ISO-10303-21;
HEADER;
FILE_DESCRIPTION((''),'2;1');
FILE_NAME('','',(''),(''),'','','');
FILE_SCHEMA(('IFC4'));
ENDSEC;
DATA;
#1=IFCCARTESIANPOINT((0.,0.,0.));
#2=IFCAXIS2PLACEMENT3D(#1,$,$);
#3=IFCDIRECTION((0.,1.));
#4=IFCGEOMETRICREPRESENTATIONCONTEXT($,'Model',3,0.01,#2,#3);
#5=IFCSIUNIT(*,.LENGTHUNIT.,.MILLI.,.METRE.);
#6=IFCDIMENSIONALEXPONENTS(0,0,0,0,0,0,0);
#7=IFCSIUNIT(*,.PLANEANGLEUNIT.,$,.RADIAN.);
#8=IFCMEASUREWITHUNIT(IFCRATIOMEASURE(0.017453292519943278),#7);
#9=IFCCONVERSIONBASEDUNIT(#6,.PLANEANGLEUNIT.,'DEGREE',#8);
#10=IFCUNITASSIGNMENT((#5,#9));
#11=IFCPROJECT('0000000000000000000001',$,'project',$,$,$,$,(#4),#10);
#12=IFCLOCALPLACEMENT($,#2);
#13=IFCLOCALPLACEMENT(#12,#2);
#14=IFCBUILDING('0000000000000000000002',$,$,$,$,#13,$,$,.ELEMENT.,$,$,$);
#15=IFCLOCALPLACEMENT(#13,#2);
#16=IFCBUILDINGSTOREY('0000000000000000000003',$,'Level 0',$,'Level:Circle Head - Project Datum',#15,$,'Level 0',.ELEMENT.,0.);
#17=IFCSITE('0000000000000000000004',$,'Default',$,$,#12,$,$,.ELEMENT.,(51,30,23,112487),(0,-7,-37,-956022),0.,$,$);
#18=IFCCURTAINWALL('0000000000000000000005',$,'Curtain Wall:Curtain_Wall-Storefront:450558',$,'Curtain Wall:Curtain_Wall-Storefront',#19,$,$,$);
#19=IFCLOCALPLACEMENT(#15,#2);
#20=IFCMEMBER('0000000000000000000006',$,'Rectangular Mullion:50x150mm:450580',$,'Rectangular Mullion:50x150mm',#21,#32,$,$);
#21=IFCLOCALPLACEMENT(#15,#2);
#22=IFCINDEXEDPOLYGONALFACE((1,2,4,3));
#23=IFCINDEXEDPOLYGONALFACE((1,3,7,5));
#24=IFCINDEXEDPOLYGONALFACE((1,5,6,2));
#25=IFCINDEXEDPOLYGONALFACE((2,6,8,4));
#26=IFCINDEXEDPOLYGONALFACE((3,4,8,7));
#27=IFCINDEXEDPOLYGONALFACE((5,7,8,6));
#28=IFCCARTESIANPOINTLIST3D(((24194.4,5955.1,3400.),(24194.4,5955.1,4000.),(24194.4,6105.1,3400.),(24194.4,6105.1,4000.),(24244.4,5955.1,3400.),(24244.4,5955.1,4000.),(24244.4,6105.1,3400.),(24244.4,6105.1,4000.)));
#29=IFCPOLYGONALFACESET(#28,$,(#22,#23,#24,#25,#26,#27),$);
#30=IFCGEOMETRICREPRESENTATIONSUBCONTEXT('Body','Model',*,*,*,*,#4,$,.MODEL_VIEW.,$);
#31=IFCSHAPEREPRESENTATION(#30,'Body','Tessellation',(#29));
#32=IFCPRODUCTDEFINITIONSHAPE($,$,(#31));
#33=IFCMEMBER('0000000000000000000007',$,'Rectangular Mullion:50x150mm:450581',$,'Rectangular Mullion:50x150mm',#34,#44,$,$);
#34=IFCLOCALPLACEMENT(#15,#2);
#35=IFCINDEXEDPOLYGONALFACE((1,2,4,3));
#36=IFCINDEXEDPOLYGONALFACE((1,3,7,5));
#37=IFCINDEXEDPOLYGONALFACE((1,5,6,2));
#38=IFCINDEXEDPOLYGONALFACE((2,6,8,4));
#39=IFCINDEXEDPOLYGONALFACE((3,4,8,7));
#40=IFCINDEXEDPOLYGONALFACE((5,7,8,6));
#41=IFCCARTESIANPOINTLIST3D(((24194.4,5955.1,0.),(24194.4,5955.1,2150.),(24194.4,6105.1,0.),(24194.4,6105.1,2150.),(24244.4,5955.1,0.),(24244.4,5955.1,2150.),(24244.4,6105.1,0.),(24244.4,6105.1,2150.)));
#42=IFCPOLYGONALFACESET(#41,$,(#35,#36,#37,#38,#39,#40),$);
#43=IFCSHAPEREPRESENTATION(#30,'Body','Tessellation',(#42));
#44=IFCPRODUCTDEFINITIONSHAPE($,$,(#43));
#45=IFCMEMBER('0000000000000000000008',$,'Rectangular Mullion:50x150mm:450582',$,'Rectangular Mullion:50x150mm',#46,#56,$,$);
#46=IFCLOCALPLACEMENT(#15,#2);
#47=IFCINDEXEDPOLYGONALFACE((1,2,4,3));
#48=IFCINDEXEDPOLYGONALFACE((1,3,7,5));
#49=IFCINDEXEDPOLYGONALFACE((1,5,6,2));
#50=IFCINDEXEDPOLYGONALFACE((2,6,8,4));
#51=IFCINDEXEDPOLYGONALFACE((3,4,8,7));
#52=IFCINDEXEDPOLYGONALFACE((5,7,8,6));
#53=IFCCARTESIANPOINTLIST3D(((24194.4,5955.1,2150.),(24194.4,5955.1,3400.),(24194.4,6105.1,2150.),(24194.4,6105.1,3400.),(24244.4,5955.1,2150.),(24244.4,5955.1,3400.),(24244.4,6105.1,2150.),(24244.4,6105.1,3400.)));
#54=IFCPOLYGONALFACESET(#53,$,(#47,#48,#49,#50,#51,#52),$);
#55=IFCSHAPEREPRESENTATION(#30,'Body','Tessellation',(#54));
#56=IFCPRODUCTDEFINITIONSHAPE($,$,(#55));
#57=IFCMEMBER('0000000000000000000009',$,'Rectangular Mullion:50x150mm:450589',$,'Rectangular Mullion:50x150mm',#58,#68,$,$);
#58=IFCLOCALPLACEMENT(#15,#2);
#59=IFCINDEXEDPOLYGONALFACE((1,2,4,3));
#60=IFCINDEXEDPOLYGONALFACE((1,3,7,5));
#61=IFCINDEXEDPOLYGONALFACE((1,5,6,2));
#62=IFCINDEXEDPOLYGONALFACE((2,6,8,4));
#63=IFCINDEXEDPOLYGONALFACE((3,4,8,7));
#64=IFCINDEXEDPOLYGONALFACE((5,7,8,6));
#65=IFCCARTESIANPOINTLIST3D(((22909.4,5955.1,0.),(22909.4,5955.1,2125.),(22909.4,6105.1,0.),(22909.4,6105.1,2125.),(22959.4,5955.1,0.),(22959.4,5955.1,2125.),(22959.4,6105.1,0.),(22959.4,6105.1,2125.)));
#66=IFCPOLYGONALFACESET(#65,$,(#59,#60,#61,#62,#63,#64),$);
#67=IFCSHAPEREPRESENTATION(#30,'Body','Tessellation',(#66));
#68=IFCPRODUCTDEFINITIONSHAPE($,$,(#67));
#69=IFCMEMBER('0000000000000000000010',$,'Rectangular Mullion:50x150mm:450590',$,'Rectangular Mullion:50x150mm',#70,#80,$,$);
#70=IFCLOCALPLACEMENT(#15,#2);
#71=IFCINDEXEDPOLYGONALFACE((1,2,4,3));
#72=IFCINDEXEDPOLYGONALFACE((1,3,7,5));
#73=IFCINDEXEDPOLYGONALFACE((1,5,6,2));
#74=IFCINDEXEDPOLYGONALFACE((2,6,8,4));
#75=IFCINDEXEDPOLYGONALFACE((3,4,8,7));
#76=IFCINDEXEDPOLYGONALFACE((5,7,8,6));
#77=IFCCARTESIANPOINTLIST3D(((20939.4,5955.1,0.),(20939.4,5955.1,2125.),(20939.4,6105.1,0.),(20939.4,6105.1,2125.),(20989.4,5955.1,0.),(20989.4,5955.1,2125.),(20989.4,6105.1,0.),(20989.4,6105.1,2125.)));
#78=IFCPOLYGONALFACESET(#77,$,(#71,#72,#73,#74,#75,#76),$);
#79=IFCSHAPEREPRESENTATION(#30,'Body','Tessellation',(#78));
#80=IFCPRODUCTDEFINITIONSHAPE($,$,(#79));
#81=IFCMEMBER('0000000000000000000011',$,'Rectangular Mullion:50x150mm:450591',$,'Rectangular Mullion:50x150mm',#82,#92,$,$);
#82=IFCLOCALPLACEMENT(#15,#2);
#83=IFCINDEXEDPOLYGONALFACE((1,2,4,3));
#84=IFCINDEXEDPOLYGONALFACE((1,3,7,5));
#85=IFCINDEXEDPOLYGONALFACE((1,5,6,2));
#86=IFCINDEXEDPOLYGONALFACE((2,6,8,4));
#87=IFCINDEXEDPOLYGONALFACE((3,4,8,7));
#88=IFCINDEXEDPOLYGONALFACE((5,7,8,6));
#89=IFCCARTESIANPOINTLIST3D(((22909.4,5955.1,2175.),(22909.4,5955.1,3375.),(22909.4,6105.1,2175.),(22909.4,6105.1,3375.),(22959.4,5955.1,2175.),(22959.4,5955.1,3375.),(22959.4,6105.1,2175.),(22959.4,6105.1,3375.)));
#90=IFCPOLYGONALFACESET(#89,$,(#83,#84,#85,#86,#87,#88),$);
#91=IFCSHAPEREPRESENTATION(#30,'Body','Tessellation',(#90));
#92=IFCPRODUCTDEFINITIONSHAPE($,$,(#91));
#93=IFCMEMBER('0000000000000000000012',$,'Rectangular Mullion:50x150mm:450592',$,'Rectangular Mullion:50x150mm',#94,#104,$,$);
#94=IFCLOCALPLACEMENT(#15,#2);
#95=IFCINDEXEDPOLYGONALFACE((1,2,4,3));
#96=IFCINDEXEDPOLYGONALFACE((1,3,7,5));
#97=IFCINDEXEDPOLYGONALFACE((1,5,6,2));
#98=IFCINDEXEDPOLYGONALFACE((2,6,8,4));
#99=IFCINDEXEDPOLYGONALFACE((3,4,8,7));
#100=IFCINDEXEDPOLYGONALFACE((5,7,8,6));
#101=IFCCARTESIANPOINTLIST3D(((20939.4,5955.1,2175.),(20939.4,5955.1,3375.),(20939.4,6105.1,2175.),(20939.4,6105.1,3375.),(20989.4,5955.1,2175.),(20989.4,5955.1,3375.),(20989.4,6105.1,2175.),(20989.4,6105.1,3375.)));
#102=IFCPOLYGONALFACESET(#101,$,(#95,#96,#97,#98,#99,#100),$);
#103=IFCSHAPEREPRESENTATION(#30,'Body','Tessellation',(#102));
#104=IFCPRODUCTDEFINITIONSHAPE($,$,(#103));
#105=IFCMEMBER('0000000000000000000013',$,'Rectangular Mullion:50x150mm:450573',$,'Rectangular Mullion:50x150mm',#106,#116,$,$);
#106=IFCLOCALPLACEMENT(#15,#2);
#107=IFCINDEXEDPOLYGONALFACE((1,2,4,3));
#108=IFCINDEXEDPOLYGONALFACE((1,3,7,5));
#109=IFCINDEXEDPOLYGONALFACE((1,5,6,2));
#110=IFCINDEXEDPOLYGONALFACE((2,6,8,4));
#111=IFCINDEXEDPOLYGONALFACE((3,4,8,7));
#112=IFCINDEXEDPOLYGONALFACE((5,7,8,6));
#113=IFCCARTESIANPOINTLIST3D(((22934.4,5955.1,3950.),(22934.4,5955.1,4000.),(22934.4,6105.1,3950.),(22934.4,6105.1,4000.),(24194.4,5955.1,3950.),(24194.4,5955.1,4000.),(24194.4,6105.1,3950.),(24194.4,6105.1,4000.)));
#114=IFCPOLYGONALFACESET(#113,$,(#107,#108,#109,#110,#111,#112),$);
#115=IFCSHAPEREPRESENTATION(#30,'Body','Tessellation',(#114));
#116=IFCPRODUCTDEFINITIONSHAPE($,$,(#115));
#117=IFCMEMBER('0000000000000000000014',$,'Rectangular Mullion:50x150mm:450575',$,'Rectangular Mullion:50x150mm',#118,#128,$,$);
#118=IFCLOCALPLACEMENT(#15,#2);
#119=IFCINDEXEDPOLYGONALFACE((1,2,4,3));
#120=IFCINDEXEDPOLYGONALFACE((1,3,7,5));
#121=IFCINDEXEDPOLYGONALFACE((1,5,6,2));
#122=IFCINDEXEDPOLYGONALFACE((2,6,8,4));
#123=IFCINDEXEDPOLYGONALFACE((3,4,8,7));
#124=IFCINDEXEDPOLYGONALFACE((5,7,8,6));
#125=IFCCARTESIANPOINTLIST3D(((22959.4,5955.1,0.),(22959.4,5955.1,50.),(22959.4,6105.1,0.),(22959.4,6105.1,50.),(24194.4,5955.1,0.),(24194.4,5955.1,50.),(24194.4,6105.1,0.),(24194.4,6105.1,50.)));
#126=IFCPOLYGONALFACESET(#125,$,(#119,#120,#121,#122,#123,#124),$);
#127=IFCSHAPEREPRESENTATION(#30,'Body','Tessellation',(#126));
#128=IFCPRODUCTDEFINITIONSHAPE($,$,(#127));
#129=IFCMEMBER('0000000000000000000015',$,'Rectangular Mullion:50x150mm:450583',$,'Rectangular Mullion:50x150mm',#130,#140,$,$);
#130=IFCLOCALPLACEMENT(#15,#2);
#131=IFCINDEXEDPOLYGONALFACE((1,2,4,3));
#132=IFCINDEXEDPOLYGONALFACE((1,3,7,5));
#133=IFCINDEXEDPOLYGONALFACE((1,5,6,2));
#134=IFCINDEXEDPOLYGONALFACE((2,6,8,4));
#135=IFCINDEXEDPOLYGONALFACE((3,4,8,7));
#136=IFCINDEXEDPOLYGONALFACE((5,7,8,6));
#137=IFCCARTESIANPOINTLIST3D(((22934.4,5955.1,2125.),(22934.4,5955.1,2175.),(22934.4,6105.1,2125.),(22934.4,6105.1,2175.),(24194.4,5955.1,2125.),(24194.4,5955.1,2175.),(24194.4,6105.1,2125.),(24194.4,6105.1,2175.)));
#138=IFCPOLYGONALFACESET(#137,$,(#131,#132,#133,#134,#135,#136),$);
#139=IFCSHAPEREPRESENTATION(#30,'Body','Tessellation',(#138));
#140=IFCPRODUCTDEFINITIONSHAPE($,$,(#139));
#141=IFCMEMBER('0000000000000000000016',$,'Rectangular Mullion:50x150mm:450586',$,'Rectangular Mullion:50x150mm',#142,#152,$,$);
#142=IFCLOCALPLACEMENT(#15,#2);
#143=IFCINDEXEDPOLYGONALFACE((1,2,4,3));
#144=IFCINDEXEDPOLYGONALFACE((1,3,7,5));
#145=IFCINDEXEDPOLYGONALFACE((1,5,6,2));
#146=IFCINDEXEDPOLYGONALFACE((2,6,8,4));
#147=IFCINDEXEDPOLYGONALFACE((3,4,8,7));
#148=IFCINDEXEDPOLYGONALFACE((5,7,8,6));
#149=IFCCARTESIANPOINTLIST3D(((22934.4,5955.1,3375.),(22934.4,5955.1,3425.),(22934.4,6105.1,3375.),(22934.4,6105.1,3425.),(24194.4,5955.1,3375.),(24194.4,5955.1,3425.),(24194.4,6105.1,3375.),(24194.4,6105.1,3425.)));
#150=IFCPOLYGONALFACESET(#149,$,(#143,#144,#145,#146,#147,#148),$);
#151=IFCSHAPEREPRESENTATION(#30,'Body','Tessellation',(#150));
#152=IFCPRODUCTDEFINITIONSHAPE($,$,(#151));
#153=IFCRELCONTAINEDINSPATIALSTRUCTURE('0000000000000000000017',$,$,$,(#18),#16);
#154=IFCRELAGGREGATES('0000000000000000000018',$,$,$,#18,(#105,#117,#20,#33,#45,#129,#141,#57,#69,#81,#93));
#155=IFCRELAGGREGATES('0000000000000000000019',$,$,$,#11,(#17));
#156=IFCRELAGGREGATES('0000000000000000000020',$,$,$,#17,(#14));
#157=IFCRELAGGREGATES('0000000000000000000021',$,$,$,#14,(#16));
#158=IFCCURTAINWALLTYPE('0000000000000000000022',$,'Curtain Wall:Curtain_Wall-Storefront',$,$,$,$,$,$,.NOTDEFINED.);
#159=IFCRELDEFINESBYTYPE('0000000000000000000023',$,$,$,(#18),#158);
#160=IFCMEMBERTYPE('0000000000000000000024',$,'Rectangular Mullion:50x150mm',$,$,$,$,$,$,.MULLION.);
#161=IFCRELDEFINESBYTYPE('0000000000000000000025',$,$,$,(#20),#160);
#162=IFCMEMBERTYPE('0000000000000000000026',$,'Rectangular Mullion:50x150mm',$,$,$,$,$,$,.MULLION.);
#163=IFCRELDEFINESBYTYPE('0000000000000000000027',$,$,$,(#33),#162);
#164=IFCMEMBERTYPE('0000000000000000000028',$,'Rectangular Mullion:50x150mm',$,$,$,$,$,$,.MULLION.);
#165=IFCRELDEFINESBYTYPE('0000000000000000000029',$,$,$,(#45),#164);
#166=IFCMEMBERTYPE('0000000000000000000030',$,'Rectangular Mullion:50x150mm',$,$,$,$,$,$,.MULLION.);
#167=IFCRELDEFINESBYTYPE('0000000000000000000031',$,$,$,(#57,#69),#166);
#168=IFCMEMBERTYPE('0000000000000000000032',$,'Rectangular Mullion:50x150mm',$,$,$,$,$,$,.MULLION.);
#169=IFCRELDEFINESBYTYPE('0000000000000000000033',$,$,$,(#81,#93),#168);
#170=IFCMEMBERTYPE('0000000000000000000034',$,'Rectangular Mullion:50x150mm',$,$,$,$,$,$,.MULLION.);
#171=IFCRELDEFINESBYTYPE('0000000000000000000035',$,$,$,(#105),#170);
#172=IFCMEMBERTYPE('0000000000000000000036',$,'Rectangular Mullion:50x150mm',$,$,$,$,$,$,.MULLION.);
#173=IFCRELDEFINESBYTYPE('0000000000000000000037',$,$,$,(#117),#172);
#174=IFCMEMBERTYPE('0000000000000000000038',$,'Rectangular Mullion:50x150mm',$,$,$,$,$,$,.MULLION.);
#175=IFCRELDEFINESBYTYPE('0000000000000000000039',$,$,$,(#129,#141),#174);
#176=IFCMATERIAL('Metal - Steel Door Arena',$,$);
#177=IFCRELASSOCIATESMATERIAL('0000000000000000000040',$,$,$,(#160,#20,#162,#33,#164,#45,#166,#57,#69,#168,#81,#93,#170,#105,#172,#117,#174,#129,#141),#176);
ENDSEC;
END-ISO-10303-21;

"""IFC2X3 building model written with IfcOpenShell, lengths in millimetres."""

from ifc_helpers import new_model, entity, si_unit, converted_unit, direction, frame, origin, origin_2d_with_axis, place, context, subcontext, project, spatial, rectangle, extrude, source, transform, mapped, material, type_object, type_shapes, element, aggregate, save


model = new_model("IFC2X3")

# Units and contexts
model_context = context("Model", 3, precision=0.01, world=origin(), true_north=direction((0.0, 1.0)))
body_context = subcontext(model_context, "Body", "Model", "MODEL_VIEW")
ifc_project = project(units=[si_unit("LENGTHUNIT", "METRE", prefix="MILLI"), converted_unit("PLANEANGLEUNIT", "DEGREE", entity("IfcRatioMeasure", 0.017453292519943278), si_unit("PLANEANGLEUNIT", "RADIAN"), dimensions=[0, 0, 0, 0, 0, 0, 0])], contexts=[model_context])

# Site, building, storey
site_placement = place(None, origin())
site = spatial("IfcSite", under=ifc_project, at=site_placement, Name="Default", CompositionType="ELEMENT", RefLatitude=(51, 30, 23, 112487), RefLongitude=(0, -7, -37, -956022), RefElevation=0.0)
building_placement = place(site_placement, origin())
building = spatial("IfcBuilding", under=site, at=building_placement, CompositionType="ELEMENT")
storey_placement = place(building_placement, origin())
storey = spatial("IfcBuildingStorey", under=building, at=storey_placement, Name="Level 0", ObjectType="Level:Circle Head - Project Datum", LongName="Level 0", CompositionType="ELEMENT", Elevation=0.0)

# Curtain wall, members
curtain_wall_type = type_object("IfcCurtainWallType", Name="Curtain Wall:Curtain_Wall-Storefront", PredefinedType="NOTDEFINED")
curtain_wall_placement = place(storey_placement, origin())
curtain_wall = element("IfcCurtainWall", 1, at=curtain_wall_placement, inside=storey, type_object=curtain_wall_type, Name="Curtain Wall:Curtain_Wall-Storefront:450558", ObjectType="Curtain Wall:Curtain_Wall-Storefront")
ifc_material_1 = material(Name="Metal - Steel Door Arena")
member_type_1 = type_object("IfcMemberType", Name="Rectangular Mullion:50x150mm", PredefinedType="MULLION", material=ifc_material_1)
shared_shape_1 = source(origin(), body_context, "Body", "SweptSolid", [
    extrude(rectangle(XDim=150.0, YDim=50.0, at=origin_2d_with_axis()), frame((-25.0, 0.0, -600.0), z_axis=(0.0, 0.0, 1.0), x_axis=(0.0, -1.0, 0.0)), (0.0, 0.0, 1.0), 600.0),
])
type_shapes(member_type_1, [shared_shape_1])
member_1_placement = place(curtain_wall_placement, frame((24244.4, 6030.1, 4000.0)))
member_1 = element("IfcMember", 2, at=member_1_placement, type_object=member_type_1, material=ifc_material_1, Name="Rectangular Mullion:50x150mm:450580", ObjectType="Rectangular Mullion:50x150mm", context=body_context, shape_type="MappedRepresentation", body=[
    mapped(shared_shape_1, transform((0.0, 0.0, 0.0), scale=1.0)),
])
member_type_2 = type_object("IfcMemberType", Name="Rectangular Mullion:50x150mm", PredefinedType="MULLION", material=ifc_material_1)
shared_shape_2 = source(origin(), body_context, "Body", "SweptSolid", [
    extrude(rectangle(XDim=150.0, YDim=50.0, at=origin_2d_with_axis()), frame((-25.0, 0.0, -2150.0), z_axis=(0.0, 0.0, 1.0), x_axis=(0.0, -1.0, 0.0)), (0.0, 0.0, 1.0), 2150.0),
])
type_shapes(member_type_2, [shared_shape_2])
member_2_placement = place(curtain_wall_placement, frame((24244.4, 6030.1, 2150.0)))
member_2 = element("IfcMember", 3, at=member_2_placement, type_object=member_type_2, material=ifc_material_1, Name="Rectangular Mullion:50x150mm:450581", ObjectType="Rectangular Mullion:50x150mm", context=body_context, shape_type="MappedRepresentation", body=[
    mapped(shared_shape_2, transform((0.0, 0.0, 0.0), scale=1.0)),
])
member_type_3 = type_object("IfcMemberType", Name="Rectangular Mullion:50x150mm", PredefinedType="MULLION", material=ifc_material_1)
shared_shape_3 = source(origin(), body_context, "Body", "SweptSolid", [
    extrude(rectangle(XDim=150.0, YDim=50.0, at=origin_2d_with_axis()), frame((-25.0, 0.0, -1250.0), z_axis=(0.0, 0.0, 1.0), x_axis=(0.0, -1.0, 0.0)), (0.0, 0.0, 1.0), 1250.0),
])
type_shapes(member_type_3, [shared_shape_3])
member_3_placement = place(curtain_wall_placement, frame((24244.4, 6030.1, 3400.0)))
member_3 = element("IfcMember", 4, at=member_3_placement, type_object=member_type_3, material=ifc_material_1, Name="Rectangular Mullion:50x150mm:450582", ObjectType="Rectangular Mullion:50x150mm", context=body_context, shape_type="MappedRepresentation", body=[
    mapped(shared_shape_3, transform((0.0, 0.0, 0.0), scale=1.0)),
])
member_type_4 = type_object("IfcMemberType", Name="Rectangular Mullion:50x150mm", PredefinedType="MULLION", material=ifc_material_1)
shared_shape_4 = source(origin(), body_context, "Body", "SweptSolid", [
    extrude(rectangle(XDim=150.0, YDim=50.0, at=origin_2d_with_axis()), frame((0.0, 0.0, -2125.0), z_axis=(0.0, 0.0, 1.0), x_axis=(0.0, -1.0, 0.0)), (0.0, 0.0, 1.0), 2125.0),
])
type_shapes(member_type_4, [shared_shape_4])
member_4_placement = place(curtain_wall_placement, frame((22934.4, 6030.1, 0.0), z_axis=(0.0, 0.0, -1.0), x_axis=(-1.0, 0.0, 0.0)))
member_4 = element("IfcMember", 5, at=member_4_placement, type_object=member_type_4, material=ifc_material_1, Name="Rectangular Mullion:50x150mm:450589", ObjectType="Rectangular Mullion:50x150mm", context=body_context, shape_type="MappedRepresentation", body=[
    mapped(shared_shape_4, transform((0.0, 0.0, 0.0), scale=1.0)),
])
member_5_placement = place(curtain_wall_placement, frame((20964.4, 6030.1, 0.0), z_axis=(0.0, 0.0, -1.0), x_axis=(-1.0, 0.0, 0.0)))
member_5 = element("IfcMember", 6, at=member_5_placement, type_object=member_type_4, material=ifc_material_1, Name="Rectangular Mullion:50x150mm:450590", ObjectType="Rectangular Mullion:50x150mm", context=body_context, shape_type="MappedRepresentation", body=[
    mapped(shared_shape_4, transform((0.0, 0.0, 0.0), scale=1.0)),
])
member_type_5 = type_object("IfcMemberType", Name="Rectangular Mullion:50x150mm", PredefinedType="MULLION", material=ifc_material_1)
shared_shape_5 = source(origin(), body_context, "Body", "SweptSolid", [
    extrude(rectangle(XDim=150.0, YDim=50.0, at=origin_2d_with_axis()), frame((0.0, 0.0, -1200.0), z_axis=(0.0, 0.0, 1.0), x_axis=(0.0, -1.0, 0.0)), (0.0, 0.0, 1.0), 1200.0),
])
type_shapes(member_type_5, [shared_shape_5])
member_6_placement = place(curtain_wall_placement, frame((22934.4, 6030.1, 2175.0), z_axis=(0.0, 0.0, -1.0), x_axis=(-1.0, 0.0, 0.0)))
member_6 = element("IfcMember", 7, at=member_6_placement, type_object=member_type_5, material=ifc_material_1, Name="Rectangular Mullion:50x150mm:450591", ObjectType="Rectangular Mullion:50x150mm", context=body_context, shape_type="MappedRepresentation", body=[
    mapped(shared_shape_5, transform((0.0, 0.0, 0.0), scale=1.0)),
])
member_7_placement = place(curtain_wall_placement, frame((20964.4, 6030.1, 2175.0), z_axis=(0.0, 0.0, -1.0), x_axis=(-1.0, 0.0, 0.0)))
member_7 = element("IfcMember", 8, at=member_7_placement, type_object=member_type_5, material=ifc_material_1, Name="Rectangular Mullion:50x150mm:450592", ObjectType="Rectangular Mullion:50x150mm", context=body_context, shape_type="MappedRepresentation", body=[
    mapped(shared_shape_5, transform((0.0, 0.0, 0.0), scale=1.0)),
])
member_type_6 = type_object("IfcMemberType", Name="Rectangular Mullion:50x150mm", PredefinedType="MULLION", material=ifc_material_1)
shared_shape_6 = source(origin(), body_context, "Body", "SweptSolid", [
    extrude(rectangle(XDim=150.0, YDim=50.0, at=origin_2d_with_axis()), frame((-25.0, 0.0, -1260.0), z_axis=(0.0, 0.0, 1.0), x_axis=(0.0, -1.0, 0.0)), (0.0, 0.0, 1.0), 1260.0),
])
type_shapes(member_type_6, [shared_shape_6])
member_8_placement = place(curtain_wall_placement, frame((22934.4, 6030.1, 4000.0), z_axis=(-1.0, 0.0, 0.0), x_axis=(0.0, 0.0, 1.0)))
member_8 = element("IfcMember", 9, at=member_8_placement, type_object=member_type_6, material=ifc_material_1, Name="Rectangular Mullion:50x150mm:450573", ObjectType="Rectangular Mullion:50x150mm", context=body_context, shape_type="MappedRepresentation", body=[
    mapped(shared_shape_6, transform((0.0, 0.0, 0.0), scale=1.0)),
])
member_type_7 = type_object("IfcMemberType", Name="Rectangular Mullion:50x150mm", PredefinedType="MULLION", material=ifc_material_1)
shared_shape_7 = source(origin(), body_context, "Body", "SweptSolid", [
    extrude(rectangle(XDim=150.0, YDim=50.0, at=origin_2d_with_axis()), frame((-25.0, 0.0, -1235.0), z_axis=(0.0, 0.0, 1.0), x_axis=(0.0, -1.0, 0.0)), (0.0, 0.0, 1.0), 1235.0),
])
type_shapes(member_type_7, [shared_shape_7])
member_9_placement = place(curtain_wall_placement, frame((24194.4, 6030.1, 0.0), z_axis=(1.0, 0.0, 0.0), x_axis=(0.0, 0.0, -1.0)))
member_9 = element("IfcMember", 10, at=member_9_placement, type_object=member_type_7, material=ifc_material_1, Name="Rectangular Mullion:50x150mm:450575", ObjectType="Rectangular Mullion:50x150mm", context=body_context, shape_type="MappedRepresentation", body=[
    mapped(shared_shape_7, transform((0.0, 0.0, 0.0), scale=1.0)),
])
member_type_8 = type_object("IfcMemberType", Name="Rectangular Mullion:50x150mm", PredefinedType="MULLION", material=ifc_material_1)
shared_shape_8 = source(origin(), body_context, "Body", "SweptSolid", [
    extrude(rectangle(XDim=150.0, YDim=50.0, at=origin_2d_with_axis()), frame((0.0, 0.0, -1260.0), z_axis=(0.0, 0.0, 1.0), x_axis=(0.0, -1.0, 0.0)), (0.0, 0.0, 1.0), 1260.0),
])
type_shapes(member_type_8, [shared_shape_8])
member_10_placement = place(curtain_wall_placement, frame((22934.4, 6030.1, 2150.0), z_axis=(-1.0, 0.0, 0.0), x_axis=(0.0, 0.0, 1.0)))
member_10 = element("IfcMember", 11, at=member_10_placement, type_object=member_type_8, material=ifc_material_1, Name="Rectangular Mullion:50x150mm:450583", ObjectType="Rectangular Mullion:50x150mm", context=body_context, shape_type="MappedRepresentation", body=[
    mapped(shared_shape_8, transform((0.0, 0.0, 0.0), scale=1.0)),
])
member_11_placement = place(curtain_wall_placement, frame((22934.4, 6030.1, 3400.0), z_axis=(-1.0, 0.0, 0.0), x_axis=(0.0, 0.0, 1.0)))
member_11 = element("IfcMember", 12, at=member_11_placement, type_object=member_type_8, material=ifc_material_1, Name="Rectangular Mullion:50x150mm:450586", ObjectType="Rectangular Mullion:50x150mm", context=body_context, shape_type="MappedRepresentation", body=[
    mapped(shared_shape_8, transform((0.0, 0.0, 0.0), scale=1.0)),
])
aggregate(curtain_wall, [member_8, member_9, member_1, member_2, member_3, member_10, member_11, member_4, member_5, member_6, member_7])

save(model, "model.ifc")
